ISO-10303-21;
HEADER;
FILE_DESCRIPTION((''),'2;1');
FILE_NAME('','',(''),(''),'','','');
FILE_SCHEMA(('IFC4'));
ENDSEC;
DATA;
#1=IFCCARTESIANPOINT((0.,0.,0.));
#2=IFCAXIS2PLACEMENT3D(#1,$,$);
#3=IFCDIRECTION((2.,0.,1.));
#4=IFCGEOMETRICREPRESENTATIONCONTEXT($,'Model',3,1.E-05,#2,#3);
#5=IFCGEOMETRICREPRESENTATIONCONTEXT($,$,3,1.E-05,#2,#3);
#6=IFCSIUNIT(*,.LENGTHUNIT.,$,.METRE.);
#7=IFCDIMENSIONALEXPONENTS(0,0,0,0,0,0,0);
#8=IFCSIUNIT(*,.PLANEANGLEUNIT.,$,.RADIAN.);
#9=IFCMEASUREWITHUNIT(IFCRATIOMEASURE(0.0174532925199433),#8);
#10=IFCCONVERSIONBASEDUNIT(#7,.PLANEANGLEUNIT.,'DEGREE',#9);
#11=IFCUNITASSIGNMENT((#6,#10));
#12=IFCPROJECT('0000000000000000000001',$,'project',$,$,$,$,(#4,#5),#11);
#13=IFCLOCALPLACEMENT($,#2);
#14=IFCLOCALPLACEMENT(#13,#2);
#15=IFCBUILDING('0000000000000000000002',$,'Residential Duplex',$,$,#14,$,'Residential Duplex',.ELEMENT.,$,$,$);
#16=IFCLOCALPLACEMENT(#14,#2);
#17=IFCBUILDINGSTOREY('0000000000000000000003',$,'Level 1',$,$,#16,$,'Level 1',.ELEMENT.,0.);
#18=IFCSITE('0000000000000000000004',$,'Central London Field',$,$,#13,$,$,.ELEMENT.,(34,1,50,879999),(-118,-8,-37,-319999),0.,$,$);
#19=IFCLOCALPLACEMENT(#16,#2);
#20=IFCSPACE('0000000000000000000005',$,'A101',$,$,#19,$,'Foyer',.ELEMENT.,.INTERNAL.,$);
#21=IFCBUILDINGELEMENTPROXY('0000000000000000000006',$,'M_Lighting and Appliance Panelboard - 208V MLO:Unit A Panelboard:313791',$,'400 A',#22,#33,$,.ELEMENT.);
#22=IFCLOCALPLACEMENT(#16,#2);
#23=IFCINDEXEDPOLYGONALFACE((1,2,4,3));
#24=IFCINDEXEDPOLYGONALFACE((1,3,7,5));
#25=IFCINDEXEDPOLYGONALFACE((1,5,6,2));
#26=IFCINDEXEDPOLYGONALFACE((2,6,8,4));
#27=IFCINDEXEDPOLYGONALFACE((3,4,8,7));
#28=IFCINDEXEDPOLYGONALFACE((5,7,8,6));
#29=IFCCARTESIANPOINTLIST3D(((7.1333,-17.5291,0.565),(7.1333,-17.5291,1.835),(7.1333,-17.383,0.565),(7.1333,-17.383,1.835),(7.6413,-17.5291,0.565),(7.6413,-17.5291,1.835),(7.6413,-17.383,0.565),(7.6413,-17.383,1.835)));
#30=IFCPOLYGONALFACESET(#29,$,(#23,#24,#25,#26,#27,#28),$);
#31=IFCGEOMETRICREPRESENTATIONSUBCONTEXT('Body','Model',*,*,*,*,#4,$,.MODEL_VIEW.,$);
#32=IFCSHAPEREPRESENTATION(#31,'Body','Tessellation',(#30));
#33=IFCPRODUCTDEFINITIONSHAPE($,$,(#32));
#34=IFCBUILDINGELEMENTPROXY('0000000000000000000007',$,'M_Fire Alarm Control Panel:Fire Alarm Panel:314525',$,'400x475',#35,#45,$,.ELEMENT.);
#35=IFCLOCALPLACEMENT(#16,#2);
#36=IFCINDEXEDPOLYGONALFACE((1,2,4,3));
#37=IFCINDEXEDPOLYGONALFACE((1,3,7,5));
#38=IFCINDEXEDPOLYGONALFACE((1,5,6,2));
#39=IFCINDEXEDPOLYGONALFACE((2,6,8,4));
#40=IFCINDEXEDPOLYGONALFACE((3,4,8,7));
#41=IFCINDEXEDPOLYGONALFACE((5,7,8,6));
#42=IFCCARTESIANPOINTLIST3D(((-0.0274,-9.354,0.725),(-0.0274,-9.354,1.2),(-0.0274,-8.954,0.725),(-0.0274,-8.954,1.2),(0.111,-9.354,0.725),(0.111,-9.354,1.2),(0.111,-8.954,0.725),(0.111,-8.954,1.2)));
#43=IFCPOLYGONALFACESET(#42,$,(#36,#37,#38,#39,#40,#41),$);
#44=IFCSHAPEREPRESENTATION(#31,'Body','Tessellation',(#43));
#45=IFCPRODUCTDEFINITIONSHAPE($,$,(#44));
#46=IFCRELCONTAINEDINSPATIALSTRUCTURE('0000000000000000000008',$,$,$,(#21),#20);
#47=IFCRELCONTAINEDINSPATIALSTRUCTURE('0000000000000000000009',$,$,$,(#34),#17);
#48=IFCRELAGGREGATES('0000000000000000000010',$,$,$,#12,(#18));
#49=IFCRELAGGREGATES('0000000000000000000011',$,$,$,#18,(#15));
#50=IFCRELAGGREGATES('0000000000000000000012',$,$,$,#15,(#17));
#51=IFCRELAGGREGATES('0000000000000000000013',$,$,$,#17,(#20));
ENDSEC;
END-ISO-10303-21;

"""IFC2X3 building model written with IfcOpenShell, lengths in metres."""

from ifc_helpers import new_model, entity, si_unit, converted_unit, direction, frame, frame_2d, origin, origin_2d_with_axis, place, context, subcontext, project, spatial, rectangle, extrude, source, transform, mapped, element, save


model = new_model("IFC2X3")

# Units and contexts
model_context = context("Model", 3, precision=1e-05, world=origin(), true_north=direction((2.0, 0.0, 1.0)))
context_of_model = context(None, 3, precision=1e-05, world=origin(), true_north=direction((2.0, 0.0, 1.0)))
body_context = subcontext(model_context, "Body", "Model", "MODEL_VIEW")
ifc_project = project(units=[si_unit("LENGTHUNIT", "METRE"), converted_unit("PLANEANGLEUNIT", "DEGREE", entity("IfcRatioMeasure", 0.0174532925199433), si_unit("PLANEANGLEUNIT", "RADIAN"), dimensions=[0, 0, 0, 0, 0, 0, 0])], contexts=[model_context, context_of_model])

# Site, building, storey, space
site_placement = place(None, origin())
site = spatial("IfcSite", under=ifc_project, at=site_placement, Name="Central London Field", CompositionType="ELEMENT", RefLatitude=(34, 1, 50, 879999), RefLongitude=(-118, -8, -37, -319999), RefElevation=0.0)
building_placement = place(site_placement, origin())
building = spatial("IfcBuilding", under=site, at=building_placement, Name="Residential Duplex", LongName="Residential Duplex", CompositionType="ELEMENT")
storey_placement = place(building_placement, origin())
storey = spatial("IfcBuildingStorey", under=building, at=storey_placement, Name="Level 1", LongName="Level 1", CompositionType="ELEMENT", Elevation=0.0)
space_1_placement = place(storey_placement, origin())
space_1 = spatial("IfcSpace", under=storey, at=space_1_placement, Name="A101", LongName="Foyer", CompositionType="ELEMENT", InteriorOrExteriorSpace="INTERNAL")

# Building element proxies
shared_shape_1 = source(origin(), body_context, "Body", "SweptSolid", [
    extrude(rectangle(XDim=0.508, YDim=1.27, at=origin_2d_with_axis()), frame((0.0, -0.4191, -0.1461), z_axis=(0.0, 0.0, 1.0), x_axis=(-1.0, 0.0, 0.0)), (0.0, 0.0, 1.0), 0.1461),
])
proxy_1_placement = place(space_1_placement, frame((7.3873, -17.383, 1.6191), z_axis=(0.0, 1.0, 0.0), x_axis=(-1.0, 0.0, 0.0)))
element("IfcBuildingElementProxy", 1, at=proxy_1_placement, inside=space_1, Name="M_Lighting and Appliance Panelboard - 208V MLO:Unit A Panelboard:313791", ObjectType="400 A", CompositionType="ELEMENT", context=body_context, shape_type="MappedRepresentation", body=[
    mapped(shared_shape_1, transform((0.0, 0.0, 0.0), scale=1.0)),
])
shared_shape_2 = source(origin(), body_context, "Body", "SweptSolid", [
    extrude(rectangle(XDim=0.4, YDim=0.475, at=frame_2d((0.0, 0.0), x_axis=(1.0, 0.0))), frame((0.0004, -0.2375, -0.111), z_axis=(0.0, 0.0, 1.0), x_axis=(-1.0, 0.0, 0.0)), (0.0, 0.0, 1.0), 0.1384),
])
proxy_2_placement = place(storey_placement, frame((0.0, -9.1536, 1.2), z_axis=(-1.0, 0.0, 0.0), x_axis=(0.0, -1.0, 0.0)))
element("IfcBuildingElementProxy", 2, at=proxy_2_placement, inside=storey, Name="M_Fire Alarm Control Panel:Fire Alarm Panel:314525", ObjectType="400x475", CompositionType="ELEMENT", context=body_context, shape_type="MappedRepresentation", body=[
    mapped(shared_shape_2, transform((0.0, 0.0, 0.0), scale=1.0)),
])

save(model, "model.ifc")
